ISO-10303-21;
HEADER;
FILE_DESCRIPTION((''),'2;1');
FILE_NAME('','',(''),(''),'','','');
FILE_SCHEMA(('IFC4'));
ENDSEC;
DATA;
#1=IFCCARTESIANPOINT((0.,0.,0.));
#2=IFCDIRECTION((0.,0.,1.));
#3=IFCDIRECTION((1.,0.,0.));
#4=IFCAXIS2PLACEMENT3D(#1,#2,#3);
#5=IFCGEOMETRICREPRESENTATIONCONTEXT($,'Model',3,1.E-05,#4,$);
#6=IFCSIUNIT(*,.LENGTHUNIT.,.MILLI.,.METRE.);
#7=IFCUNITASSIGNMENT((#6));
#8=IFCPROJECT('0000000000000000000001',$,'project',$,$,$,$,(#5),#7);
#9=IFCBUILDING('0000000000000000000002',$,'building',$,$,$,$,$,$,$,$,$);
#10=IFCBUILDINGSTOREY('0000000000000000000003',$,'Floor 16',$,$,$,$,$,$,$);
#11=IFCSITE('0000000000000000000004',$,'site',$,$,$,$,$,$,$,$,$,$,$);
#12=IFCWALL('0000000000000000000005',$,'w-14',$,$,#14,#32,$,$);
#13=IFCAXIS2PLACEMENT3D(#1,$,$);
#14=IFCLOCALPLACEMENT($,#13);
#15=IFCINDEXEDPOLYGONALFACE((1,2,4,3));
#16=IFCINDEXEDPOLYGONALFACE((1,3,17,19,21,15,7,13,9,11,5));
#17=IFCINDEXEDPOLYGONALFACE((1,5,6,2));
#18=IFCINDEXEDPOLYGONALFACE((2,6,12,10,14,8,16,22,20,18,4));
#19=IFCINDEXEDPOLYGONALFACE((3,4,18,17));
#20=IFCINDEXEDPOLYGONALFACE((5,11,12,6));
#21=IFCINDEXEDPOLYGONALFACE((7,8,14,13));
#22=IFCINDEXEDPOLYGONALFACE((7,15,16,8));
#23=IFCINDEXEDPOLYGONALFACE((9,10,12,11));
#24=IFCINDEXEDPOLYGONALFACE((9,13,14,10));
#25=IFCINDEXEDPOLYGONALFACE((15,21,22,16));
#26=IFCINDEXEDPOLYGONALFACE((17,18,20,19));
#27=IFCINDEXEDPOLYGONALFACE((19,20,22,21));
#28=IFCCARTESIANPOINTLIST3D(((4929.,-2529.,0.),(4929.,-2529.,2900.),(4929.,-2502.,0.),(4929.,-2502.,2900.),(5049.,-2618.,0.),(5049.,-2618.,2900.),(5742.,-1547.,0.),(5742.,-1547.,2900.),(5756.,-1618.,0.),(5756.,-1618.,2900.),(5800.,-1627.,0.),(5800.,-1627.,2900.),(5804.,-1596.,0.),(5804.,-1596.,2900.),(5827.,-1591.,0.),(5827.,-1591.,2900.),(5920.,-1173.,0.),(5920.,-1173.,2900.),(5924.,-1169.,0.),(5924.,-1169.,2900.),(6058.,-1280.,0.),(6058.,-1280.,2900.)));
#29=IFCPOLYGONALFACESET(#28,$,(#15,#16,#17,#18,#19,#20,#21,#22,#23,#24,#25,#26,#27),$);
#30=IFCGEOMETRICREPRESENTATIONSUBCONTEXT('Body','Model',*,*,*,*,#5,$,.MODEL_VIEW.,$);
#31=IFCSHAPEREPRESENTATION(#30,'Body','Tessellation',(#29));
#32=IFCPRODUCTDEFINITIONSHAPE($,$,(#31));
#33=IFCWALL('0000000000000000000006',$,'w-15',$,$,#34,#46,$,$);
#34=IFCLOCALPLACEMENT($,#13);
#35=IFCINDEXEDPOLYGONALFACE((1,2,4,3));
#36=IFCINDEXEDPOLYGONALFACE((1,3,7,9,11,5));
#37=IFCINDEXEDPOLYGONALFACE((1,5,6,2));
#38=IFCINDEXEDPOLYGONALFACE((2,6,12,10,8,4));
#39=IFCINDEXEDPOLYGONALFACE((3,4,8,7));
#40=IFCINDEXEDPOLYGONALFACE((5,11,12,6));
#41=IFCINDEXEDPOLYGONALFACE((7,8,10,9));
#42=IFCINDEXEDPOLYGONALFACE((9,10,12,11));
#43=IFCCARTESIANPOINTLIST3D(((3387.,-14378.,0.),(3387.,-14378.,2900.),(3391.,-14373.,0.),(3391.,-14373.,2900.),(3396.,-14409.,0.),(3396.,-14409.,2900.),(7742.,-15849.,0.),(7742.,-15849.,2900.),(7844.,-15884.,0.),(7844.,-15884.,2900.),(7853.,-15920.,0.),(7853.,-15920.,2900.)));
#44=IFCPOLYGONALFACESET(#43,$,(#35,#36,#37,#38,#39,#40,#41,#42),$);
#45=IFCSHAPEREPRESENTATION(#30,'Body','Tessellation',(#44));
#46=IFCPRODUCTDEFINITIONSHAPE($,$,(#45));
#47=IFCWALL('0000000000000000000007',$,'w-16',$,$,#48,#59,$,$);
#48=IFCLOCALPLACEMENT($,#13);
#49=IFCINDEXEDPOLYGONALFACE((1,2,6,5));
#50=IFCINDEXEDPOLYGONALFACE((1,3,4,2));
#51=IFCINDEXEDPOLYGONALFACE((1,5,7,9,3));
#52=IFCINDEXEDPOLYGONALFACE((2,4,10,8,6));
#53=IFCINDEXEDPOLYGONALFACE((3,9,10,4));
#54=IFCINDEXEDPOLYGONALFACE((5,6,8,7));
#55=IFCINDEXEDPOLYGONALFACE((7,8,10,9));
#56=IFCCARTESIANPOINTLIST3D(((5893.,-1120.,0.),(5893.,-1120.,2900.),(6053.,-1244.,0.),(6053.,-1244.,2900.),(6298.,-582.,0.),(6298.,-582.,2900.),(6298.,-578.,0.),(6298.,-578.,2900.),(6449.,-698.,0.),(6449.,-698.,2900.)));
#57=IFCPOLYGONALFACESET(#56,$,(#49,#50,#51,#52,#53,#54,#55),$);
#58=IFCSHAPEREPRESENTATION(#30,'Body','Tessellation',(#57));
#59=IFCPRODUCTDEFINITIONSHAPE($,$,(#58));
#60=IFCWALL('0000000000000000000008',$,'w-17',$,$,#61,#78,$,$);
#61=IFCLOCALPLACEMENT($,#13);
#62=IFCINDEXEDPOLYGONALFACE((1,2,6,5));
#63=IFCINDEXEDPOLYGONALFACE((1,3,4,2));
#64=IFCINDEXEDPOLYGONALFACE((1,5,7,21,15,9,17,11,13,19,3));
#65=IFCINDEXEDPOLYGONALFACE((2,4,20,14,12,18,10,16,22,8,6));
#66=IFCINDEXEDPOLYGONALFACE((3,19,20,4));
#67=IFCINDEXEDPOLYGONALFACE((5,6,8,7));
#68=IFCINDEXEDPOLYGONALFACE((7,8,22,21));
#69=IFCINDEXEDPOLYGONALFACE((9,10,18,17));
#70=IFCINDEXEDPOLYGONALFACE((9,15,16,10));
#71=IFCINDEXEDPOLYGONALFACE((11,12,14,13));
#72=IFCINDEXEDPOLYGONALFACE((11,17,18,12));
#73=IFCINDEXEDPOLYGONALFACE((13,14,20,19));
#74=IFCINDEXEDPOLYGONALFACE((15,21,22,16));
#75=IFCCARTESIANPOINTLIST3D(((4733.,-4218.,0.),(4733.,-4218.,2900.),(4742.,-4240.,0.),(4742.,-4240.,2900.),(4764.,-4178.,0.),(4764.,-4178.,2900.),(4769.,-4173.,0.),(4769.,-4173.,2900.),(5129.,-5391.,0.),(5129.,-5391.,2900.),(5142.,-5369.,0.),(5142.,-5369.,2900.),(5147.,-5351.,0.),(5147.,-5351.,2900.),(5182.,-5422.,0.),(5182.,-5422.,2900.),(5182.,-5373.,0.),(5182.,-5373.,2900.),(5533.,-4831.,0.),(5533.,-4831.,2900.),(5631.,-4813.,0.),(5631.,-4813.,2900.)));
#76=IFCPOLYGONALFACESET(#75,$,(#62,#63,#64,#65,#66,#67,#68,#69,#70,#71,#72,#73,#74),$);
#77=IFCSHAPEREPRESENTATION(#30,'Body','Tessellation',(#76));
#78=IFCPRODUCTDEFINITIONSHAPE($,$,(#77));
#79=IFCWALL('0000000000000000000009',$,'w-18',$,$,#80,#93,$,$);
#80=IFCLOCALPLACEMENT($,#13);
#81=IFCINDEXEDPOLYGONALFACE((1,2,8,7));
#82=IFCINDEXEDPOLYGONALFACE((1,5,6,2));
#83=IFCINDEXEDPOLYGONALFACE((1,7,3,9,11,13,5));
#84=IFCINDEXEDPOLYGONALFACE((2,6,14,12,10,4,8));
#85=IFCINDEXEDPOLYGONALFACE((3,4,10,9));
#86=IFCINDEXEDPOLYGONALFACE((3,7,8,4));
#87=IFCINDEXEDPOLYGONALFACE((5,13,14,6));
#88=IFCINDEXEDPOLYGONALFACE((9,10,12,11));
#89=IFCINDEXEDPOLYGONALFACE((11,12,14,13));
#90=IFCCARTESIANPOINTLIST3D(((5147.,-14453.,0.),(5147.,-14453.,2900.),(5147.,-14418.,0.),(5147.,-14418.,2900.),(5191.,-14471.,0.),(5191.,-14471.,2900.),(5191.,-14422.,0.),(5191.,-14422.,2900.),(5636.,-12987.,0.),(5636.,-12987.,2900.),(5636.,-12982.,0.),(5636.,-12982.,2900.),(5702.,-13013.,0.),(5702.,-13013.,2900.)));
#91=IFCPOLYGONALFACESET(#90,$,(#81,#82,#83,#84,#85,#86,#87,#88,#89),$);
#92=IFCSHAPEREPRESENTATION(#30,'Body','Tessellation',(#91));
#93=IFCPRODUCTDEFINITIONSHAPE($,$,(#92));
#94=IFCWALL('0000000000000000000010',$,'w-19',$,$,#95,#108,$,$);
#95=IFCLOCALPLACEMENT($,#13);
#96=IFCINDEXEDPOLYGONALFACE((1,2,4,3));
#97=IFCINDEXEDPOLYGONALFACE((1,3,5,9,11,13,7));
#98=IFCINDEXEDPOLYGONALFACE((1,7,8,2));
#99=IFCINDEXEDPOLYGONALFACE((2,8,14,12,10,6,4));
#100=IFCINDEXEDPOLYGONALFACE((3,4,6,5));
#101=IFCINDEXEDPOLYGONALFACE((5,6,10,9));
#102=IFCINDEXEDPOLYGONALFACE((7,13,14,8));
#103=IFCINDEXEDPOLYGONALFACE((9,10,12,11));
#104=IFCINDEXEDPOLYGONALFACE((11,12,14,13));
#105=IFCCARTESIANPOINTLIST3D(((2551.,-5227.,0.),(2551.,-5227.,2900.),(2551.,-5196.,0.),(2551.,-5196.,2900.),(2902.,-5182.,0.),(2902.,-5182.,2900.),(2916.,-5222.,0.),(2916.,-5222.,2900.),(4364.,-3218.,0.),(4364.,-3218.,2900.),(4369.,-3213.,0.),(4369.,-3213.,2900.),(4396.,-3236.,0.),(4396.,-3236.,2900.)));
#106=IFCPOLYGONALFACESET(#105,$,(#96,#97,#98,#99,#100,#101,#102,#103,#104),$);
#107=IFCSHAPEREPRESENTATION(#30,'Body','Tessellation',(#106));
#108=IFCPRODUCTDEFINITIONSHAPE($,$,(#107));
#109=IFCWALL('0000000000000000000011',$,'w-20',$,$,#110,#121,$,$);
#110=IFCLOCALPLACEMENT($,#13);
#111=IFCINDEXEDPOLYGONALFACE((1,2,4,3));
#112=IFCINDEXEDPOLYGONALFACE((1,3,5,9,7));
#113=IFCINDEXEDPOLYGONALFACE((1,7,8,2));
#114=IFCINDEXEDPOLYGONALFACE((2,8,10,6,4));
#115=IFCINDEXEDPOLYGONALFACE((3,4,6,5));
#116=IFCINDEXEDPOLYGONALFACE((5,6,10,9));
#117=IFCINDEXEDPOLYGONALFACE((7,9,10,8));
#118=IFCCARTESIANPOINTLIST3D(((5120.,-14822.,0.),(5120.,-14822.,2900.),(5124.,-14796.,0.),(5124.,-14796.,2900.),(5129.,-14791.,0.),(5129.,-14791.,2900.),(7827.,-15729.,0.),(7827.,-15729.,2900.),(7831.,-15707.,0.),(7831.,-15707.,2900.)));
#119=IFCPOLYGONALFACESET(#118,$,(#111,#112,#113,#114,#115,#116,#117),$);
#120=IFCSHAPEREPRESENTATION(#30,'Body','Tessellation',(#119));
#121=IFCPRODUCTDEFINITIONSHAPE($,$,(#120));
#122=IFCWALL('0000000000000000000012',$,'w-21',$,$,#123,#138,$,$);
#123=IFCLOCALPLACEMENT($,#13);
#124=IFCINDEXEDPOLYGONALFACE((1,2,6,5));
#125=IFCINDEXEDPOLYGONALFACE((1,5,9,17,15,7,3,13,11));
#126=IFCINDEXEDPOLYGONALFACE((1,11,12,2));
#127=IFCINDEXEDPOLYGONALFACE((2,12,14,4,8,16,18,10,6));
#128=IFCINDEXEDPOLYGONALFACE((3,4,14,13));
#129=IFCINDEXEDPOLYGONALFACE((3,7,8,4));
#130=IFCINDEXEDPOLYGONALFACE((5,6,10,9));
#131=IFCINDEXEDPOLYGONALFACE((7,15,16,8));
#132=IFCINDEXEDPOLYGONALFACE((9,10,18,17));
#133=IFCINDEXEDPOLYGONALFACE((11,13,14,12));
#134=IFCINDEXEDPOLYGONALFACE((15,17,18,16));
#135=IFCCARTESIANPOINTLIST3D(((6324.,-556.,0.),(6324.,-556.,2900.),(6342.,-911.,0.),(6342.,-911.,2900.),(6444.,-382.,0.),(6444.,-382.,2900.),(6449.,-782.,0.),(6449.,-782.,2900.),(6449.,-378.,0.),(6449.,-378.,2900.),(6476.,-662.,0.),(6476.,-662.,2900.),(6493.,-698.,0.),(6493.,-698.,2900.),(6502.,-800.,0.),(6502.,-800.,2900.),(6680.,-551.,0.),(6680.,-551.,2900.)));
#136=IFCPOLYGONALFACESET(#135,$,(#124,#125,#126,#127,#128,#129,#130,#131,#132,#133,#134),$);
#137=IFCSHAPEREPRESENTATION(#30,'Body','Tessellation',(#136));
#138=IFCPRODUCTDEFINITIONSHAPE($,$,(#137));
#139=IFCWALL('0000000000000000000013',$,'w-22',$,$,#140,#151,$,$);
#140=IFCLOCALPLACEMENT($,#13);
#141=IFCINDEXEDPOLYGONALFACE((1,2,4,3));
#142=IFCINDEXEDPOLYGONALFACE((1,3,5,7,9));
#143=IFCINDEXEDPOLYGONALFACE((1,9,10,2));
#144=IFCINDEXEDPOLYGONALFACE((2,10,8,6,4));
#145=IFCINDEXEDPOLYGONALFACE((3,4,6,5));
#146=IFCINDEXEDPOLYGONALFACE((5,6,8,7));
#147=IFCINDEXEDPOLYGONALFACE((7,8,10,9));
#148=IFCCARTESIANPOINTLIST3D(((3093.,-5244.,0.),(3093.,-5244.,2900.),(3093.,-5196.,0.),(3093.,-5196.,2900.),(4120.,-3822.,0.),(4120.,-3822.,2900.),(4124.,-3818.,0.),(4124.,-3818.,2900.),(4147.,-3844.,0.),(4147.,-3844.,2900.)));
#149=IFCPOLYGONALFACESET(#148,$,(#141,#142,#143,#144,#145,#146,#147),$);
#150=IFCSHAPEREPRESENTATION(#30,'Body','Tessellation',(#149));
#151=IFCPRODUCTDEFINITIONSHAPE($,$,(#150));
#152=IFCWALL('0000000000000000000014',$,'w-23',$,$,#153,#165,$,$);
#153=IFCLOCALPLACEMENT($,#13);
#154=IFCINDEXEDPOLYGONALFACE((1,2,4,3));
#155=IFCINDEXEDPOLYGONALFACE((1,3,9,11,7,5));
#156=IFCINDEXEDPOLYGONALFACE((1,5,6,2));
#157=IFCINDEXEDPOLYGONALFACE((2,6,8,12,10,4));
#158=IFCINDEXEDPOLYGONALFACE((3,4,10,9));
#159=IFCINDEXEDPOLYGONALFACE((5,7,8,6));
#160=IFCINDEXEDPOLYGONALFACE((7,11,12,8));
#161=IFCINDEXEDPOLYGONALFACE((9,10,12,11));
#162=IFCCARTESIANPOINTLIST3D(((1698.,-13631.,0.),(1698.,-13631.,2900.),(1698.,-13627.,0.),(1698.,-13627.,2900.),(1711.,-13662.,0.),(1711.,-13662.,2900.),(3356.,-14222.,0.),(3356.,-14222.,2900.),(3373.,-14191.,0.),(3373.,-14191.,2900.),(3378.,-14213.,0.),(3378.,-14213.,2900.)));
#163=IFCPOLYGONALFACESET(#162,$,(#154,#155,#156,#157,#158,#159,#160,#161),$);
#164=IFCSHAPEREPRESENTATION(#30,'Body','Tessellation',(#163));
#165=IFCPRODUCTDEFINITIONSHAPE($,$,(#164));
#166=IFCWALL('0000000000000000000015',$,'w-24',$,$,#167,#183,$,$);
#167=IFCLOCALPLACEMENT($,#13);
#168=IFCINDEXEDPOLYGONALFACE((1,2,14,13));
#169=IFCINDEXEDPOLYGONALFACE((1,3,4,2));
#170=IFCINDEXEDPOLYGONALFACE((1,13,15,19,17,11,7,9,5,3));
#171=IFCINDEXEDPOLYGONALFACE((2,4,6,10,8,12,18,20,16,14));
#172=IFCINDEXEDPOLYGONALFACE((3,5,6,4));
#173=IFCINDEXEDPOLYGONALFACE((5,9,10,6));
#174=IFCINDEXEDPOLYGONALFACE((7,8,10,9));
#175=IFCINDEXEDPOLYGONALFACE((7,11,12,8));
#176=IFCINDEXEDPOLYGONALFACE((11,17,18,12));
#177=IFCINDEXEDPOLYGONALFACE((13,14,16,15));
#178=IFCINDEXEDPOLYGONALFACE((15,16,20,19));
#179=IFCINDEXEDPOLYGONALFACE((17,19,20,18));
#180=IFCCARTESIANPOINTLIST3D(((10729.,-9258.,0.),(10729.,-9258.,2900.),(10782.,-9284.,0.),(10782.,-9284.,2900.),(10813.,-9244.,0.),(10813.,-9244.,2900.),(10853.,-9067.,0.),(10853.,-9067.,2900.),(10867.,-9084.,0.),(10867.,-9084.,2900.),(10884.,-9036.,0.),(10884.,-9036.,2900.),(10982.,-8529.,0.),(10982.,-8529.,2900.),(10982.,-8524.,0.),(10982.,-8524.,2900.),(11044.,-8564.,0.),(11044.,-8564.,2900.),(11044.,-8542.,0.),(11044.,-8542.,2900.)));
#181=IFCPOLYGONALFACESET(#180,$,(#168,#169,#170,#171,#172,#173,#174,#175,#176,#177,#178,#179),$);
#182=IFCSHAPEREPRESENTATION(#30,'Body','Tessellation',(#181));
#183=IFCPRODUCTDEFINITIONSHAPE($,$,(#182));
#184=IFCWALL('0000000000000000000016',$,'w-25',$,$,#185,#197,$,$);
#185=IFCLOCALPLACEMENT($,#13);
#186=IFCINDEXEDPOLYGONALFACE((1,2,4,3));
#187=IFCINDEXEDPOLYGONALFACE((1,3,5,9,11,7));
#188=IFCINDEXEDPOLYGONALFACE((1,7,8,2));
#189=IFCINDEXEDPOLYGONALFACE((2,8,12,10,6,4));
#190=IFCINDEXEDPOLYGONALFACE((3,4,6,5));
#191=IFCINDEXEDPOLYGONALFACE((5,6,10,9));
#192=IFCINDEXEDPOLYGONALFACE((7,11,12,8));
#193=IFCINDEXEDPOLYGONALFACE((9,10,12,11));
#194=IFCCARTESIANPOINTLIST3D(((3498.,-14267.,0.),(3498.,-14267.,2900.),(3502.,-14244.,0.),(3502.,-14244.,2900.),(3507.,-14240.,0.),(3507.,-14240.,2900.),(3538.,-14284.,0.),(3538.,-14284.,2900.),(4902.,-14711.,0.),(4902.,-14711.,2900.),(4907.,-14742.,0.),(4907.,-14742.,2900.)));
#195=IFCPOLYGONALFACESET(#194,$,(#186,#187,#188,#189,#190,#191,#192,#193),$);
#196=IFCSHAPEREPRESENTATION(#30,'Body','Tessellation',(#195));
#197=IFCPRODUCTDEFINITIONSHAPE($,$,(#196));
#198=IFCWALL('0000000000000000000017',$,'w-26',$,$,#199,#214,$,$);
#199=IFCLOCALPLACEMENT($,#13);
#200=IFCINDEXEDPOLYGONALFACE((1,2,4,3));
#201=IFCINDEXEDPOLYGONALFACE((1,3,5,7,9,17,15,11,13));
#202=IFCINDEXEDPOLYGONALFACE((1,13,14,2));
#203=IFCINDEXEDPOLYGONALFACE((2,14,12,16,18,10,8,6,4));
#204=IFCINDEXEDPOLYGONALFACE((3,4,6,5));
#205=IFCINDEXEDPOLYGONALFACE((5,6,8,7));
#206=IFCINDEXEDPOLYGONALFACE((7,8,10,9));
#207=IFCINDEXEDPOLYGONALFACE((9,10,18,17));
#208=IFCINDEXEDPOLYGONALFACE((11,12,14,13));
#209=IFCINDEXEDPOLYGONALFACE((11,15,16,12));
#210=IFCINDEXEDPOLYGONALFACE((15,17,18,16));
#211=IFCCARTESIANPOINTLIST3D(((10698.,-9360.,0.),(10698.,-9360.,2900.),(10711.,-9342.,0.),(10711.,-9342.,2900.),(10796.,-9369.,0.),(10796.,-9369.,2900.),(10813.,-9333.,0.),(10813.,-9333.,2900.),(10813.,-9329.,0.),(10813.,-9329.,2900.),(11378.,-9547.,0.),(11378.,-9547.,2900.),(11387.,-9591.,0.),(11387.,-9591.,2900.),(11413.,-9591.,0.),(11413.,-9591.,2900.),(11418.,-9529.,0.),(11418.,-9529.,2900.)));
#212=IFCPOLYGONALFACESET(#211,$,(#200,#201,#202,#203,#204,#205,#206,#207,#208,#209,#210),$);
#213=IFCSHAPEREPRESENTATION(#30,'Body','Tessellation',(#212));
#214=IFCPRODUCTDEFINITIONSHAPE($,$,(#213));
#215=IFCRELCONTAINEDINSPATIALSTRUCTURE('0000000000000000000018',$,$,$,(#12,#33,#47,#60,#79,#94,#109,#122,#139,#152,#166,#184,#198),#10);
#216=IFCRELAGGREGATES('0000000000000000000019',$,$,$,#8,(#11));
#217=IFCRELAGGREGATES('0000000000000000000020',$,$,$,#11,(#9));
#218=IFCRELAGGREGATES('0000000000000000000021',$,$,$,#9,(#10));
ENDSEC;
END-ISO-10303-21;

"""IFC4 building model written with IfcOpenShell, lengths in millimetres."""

from ifc_helpers import new_model, si_unit, origin_with_axes, place, context, subcontext, project, spatial, indexed_curve, outline, extrude, element, save


model = new_model("IFC4")

# Units and contexts
model_context = context("Model", 3, precision=1e-05, world=origin_with_axes())
body_context = subcontext(model_context, "Body", "Model", "MODEL_VIEW")
ifc_project = project(units=[si_unit("LENGTHUNIT", "METRE", prefix="MILLI")], contexts=[model_context])

# Site, building, storey
site = spatial("IfcSite", under=ifc_project, Name="site")
building = spatial("IfcBuilding", under=site, Name="building")
storey = spatial("IfcBuildingStorey", under=building, Name="Floor 16")

# Walls
wall_1_placement = place(None, origin_with_axes())
element("IfcWall", 1, at=wall_1_placement, inside=storey, Name="w-14", context=body_context, shape_type="SweptSolid", body=[
    extrude(outline(indexed_curve([(5924.0, -1169.0), (5920.0, -1173.0), (4929.0, -2502.0), (4929.0, -2529.0), (5049.0, -2618.0), (5800.0, -1627.0), (5756.0, -1618.0), (5804.0, -1596.0), (5742.0, -1547.0), (5827.0, -1591.0), (6058.0, -1280.0)])), None, (0.0, 0.0, 1.0), 2900.0),
])
wall_2_placement = place(None, origin_with_axes())
element("IfcWall", 2, at=wall_2_placement, inside=storey, Name="w-15", context=body_context, shape_type="SweptSolid", body=[
    extrude(outline(indexed_curve([(3391.0, -14373.0), (3387.0, -14378.0), (3396.0, -14409.0), (7853.0, -15920.0), (7844.0, -15884.0), (7742.0, -15849.0)])), None, (0.0, 0.0, 1.0), 2900.0),
])
wall_3_placement = place(None, origin_with_axes())
element("IfcWall", 3, at=wall_3_placement, inside=storey, Name="w-16", context=body_context, shape_type="SweptSolid", body=[
    extrude(outline(indexed_curve([(6298.0, -578.0), (6298.0, -582.0), (5893.0, -1120.0), (6053.0, -1244.0), (6449.0, -698.0)])), None, (0.0, 0.0, 1.0), 2900.0),
])
wall_4_placement = place(None, origin_with_axes())
element("IfcWall", 4, at=wall_4_placement, inside=storey, Name="w-17", context=body_context, shape_type="SweptSolid", body=[
    extrude(outline(indexed_curve([(4769.0, -4173.0), (4764.0, -4178.0), (4733.0, -4218.0), (4742.0, -4240.0), (5533.0, -4831.0), (5147.0, -5351.0), (5142.0, -5369.0), (5182.0, -5373.0), (5129.0, -5391.0), (5182.0, -5422.0), (5631.0, -4813.0)])), None, (0.0, 0.0, 1.0), 2900.0),
])
wall_5_placement = place(None, origin_with_axes())
element("IfcWall", 5, at=wall_5_placement, inside=storey, Name="w-18", context=body_context, shape_type="SweptSolid", body=[
    extrude(outline(indexed_curve([(5636.0, -12982.0), (5636.0, -12987.0), (5147.0, -14418.0), (5191.0, -14422.0), (5147.0, -14453.0), (5191.0, -14471.0), (5702.0, -13013.0)])), None, (0.0, 0.0, 1.0), 2900.0),
])
wall_6_placement = place(None, origin_with_axes())
element("IfcWall", 6, at=wall_6_placement, inside=storey, Name="w-19", context=body_context, shape_type="SweptSolid", body=[
    extrude(outline(indexed_curve([(4369.0, -3213.0), (4364.0, -3218.0), (2902.0, -5182.0), (2551.0, -5196.0), (2551.0, -5227.0), (2916.0, -5222.0), (4396.0, -3236.0)])), None, (0.0, 0.0, 1.0), 2900.0),
])
wall_7_placement = place(None, origin_with_axes())
element("IfcWall", 7, at=wall_7_placement, inside=storey, Name="w-20", context=body_context, shape_type="SweptSolid", body=[
    extrude(outline(indexed_curve([(5129.0, -14791.0), (5124.0, -14796.0), (5120.0, -14822.0), (7827.0, -15729.0), (7831.0, -15707.0)])), None, (0.0, 0.0, 1.0), 2900.0),
])
wall_8_placement = place(None, origin_with_axes())
element("IfcWall", 8, at=wall_8_placement, inside=storey, Name="w-21", context=body_context, shape_type="SweptSolid", body=[
    extrude(outline(indexed_curve([(6449.0, -378.0), (6444.0, -382.0), (6324.0, -556.0), (6476.0, -662.0), (6493.0, -698.0), (6342.0, -911.0), (6449.0, -782.0), (6502.0, -800.0), (6680.0, -551.0)])), None, (0.0, 0.0, 1.0), 2900.0),
])
wall_9_placement = place(None, origin_with_axes())
element("IfcWall", 9, at=wall_9_placement, inside=storey, Name="w-22", context=body_context, shape_type="SweptSolid", body=[
    extrude(outline(indexed_curve([(4124.0, -3818.0), (4120.0, -3822.0), (3093.0, -5196.0), (3093.0, -5244.0), (4147.0, -3844.0)])), None, (0.0, 0.0, 1.0), 2900.0),
])
wall_10_placement = place(None, origin_with_axes())
element("IfcWall", 10, at=wall_10_placement, inside=storey, Name="w-23", context=body_context, shape_type="SweptSolid", body=[
    extrude(outline(indexed_curve([(1698.0, -13627.0), (1698.0, -13631.0), (1711.0, -13662.0), (3356.0, -14222.0), (3378.0, -14213.0), (3373.0, -14191.0)])), None, (0.0, 0.0, 1.0), 2900.0),
])
wall_11_placement = place(None, origin_with_axes())
element("IfcWall", 11, at=wall_11_placement, inside=storey, Name="w-24", context=body_context, shape_type="SweptSolid", body=[
    extrude(outline(indexed_curve([(10982.0, -8524.0), (10982.0, -8529.0), (10729.0, -9258.0), (10782.0, -9284.0), (10813.0, -9244.0), (10867.0, -9084.0), (10853.0, -9067.0), (10884.0, -9036.0), (11044.0, -8564.0), (11044.0, -8542.0)])), None, (0.0, 0.0, 1.0), 2900.0),
])
wall_12_placement = place(None, origin_with_axes())
element("IfcWall", 12, at=wall_12_placement, inside=storey, Name="w-25", context=body_context, shape_type="SweptSolid", body=[
    extrude(outline(indexed_curve([(3507.0, -14240.0), (3502.0, -14244.0), (3498.0, -14267.0), (3538.0, -14284.0), (4907.0, -14742.0), (4902.0, -14711.0)])), None, (0.0, 0.0, 1.0), 2900.0),
])
wall_13_placement = place(None, origin_with_axes())
element("IfcWall", 13, at=wall_13_placement, inside=storey, Name="w-26", context=body_context, shape_type="SweptSolid", body=[
    extrude(outline(indexed_curve([(10813.0, -9329.0), (10813.0, -9333.0), (10796.0, -9369.0), (10711.0, -9342.0), (10698.0, -9360.0), (11387.0, -9591.0), (11378.0, -9547.0), (11413.0, -9591.0), (11418.0, -9529.0)])), None, (0.0, 0.0, 1.0), 2900.0),
])

save(model, "model.ifc")
